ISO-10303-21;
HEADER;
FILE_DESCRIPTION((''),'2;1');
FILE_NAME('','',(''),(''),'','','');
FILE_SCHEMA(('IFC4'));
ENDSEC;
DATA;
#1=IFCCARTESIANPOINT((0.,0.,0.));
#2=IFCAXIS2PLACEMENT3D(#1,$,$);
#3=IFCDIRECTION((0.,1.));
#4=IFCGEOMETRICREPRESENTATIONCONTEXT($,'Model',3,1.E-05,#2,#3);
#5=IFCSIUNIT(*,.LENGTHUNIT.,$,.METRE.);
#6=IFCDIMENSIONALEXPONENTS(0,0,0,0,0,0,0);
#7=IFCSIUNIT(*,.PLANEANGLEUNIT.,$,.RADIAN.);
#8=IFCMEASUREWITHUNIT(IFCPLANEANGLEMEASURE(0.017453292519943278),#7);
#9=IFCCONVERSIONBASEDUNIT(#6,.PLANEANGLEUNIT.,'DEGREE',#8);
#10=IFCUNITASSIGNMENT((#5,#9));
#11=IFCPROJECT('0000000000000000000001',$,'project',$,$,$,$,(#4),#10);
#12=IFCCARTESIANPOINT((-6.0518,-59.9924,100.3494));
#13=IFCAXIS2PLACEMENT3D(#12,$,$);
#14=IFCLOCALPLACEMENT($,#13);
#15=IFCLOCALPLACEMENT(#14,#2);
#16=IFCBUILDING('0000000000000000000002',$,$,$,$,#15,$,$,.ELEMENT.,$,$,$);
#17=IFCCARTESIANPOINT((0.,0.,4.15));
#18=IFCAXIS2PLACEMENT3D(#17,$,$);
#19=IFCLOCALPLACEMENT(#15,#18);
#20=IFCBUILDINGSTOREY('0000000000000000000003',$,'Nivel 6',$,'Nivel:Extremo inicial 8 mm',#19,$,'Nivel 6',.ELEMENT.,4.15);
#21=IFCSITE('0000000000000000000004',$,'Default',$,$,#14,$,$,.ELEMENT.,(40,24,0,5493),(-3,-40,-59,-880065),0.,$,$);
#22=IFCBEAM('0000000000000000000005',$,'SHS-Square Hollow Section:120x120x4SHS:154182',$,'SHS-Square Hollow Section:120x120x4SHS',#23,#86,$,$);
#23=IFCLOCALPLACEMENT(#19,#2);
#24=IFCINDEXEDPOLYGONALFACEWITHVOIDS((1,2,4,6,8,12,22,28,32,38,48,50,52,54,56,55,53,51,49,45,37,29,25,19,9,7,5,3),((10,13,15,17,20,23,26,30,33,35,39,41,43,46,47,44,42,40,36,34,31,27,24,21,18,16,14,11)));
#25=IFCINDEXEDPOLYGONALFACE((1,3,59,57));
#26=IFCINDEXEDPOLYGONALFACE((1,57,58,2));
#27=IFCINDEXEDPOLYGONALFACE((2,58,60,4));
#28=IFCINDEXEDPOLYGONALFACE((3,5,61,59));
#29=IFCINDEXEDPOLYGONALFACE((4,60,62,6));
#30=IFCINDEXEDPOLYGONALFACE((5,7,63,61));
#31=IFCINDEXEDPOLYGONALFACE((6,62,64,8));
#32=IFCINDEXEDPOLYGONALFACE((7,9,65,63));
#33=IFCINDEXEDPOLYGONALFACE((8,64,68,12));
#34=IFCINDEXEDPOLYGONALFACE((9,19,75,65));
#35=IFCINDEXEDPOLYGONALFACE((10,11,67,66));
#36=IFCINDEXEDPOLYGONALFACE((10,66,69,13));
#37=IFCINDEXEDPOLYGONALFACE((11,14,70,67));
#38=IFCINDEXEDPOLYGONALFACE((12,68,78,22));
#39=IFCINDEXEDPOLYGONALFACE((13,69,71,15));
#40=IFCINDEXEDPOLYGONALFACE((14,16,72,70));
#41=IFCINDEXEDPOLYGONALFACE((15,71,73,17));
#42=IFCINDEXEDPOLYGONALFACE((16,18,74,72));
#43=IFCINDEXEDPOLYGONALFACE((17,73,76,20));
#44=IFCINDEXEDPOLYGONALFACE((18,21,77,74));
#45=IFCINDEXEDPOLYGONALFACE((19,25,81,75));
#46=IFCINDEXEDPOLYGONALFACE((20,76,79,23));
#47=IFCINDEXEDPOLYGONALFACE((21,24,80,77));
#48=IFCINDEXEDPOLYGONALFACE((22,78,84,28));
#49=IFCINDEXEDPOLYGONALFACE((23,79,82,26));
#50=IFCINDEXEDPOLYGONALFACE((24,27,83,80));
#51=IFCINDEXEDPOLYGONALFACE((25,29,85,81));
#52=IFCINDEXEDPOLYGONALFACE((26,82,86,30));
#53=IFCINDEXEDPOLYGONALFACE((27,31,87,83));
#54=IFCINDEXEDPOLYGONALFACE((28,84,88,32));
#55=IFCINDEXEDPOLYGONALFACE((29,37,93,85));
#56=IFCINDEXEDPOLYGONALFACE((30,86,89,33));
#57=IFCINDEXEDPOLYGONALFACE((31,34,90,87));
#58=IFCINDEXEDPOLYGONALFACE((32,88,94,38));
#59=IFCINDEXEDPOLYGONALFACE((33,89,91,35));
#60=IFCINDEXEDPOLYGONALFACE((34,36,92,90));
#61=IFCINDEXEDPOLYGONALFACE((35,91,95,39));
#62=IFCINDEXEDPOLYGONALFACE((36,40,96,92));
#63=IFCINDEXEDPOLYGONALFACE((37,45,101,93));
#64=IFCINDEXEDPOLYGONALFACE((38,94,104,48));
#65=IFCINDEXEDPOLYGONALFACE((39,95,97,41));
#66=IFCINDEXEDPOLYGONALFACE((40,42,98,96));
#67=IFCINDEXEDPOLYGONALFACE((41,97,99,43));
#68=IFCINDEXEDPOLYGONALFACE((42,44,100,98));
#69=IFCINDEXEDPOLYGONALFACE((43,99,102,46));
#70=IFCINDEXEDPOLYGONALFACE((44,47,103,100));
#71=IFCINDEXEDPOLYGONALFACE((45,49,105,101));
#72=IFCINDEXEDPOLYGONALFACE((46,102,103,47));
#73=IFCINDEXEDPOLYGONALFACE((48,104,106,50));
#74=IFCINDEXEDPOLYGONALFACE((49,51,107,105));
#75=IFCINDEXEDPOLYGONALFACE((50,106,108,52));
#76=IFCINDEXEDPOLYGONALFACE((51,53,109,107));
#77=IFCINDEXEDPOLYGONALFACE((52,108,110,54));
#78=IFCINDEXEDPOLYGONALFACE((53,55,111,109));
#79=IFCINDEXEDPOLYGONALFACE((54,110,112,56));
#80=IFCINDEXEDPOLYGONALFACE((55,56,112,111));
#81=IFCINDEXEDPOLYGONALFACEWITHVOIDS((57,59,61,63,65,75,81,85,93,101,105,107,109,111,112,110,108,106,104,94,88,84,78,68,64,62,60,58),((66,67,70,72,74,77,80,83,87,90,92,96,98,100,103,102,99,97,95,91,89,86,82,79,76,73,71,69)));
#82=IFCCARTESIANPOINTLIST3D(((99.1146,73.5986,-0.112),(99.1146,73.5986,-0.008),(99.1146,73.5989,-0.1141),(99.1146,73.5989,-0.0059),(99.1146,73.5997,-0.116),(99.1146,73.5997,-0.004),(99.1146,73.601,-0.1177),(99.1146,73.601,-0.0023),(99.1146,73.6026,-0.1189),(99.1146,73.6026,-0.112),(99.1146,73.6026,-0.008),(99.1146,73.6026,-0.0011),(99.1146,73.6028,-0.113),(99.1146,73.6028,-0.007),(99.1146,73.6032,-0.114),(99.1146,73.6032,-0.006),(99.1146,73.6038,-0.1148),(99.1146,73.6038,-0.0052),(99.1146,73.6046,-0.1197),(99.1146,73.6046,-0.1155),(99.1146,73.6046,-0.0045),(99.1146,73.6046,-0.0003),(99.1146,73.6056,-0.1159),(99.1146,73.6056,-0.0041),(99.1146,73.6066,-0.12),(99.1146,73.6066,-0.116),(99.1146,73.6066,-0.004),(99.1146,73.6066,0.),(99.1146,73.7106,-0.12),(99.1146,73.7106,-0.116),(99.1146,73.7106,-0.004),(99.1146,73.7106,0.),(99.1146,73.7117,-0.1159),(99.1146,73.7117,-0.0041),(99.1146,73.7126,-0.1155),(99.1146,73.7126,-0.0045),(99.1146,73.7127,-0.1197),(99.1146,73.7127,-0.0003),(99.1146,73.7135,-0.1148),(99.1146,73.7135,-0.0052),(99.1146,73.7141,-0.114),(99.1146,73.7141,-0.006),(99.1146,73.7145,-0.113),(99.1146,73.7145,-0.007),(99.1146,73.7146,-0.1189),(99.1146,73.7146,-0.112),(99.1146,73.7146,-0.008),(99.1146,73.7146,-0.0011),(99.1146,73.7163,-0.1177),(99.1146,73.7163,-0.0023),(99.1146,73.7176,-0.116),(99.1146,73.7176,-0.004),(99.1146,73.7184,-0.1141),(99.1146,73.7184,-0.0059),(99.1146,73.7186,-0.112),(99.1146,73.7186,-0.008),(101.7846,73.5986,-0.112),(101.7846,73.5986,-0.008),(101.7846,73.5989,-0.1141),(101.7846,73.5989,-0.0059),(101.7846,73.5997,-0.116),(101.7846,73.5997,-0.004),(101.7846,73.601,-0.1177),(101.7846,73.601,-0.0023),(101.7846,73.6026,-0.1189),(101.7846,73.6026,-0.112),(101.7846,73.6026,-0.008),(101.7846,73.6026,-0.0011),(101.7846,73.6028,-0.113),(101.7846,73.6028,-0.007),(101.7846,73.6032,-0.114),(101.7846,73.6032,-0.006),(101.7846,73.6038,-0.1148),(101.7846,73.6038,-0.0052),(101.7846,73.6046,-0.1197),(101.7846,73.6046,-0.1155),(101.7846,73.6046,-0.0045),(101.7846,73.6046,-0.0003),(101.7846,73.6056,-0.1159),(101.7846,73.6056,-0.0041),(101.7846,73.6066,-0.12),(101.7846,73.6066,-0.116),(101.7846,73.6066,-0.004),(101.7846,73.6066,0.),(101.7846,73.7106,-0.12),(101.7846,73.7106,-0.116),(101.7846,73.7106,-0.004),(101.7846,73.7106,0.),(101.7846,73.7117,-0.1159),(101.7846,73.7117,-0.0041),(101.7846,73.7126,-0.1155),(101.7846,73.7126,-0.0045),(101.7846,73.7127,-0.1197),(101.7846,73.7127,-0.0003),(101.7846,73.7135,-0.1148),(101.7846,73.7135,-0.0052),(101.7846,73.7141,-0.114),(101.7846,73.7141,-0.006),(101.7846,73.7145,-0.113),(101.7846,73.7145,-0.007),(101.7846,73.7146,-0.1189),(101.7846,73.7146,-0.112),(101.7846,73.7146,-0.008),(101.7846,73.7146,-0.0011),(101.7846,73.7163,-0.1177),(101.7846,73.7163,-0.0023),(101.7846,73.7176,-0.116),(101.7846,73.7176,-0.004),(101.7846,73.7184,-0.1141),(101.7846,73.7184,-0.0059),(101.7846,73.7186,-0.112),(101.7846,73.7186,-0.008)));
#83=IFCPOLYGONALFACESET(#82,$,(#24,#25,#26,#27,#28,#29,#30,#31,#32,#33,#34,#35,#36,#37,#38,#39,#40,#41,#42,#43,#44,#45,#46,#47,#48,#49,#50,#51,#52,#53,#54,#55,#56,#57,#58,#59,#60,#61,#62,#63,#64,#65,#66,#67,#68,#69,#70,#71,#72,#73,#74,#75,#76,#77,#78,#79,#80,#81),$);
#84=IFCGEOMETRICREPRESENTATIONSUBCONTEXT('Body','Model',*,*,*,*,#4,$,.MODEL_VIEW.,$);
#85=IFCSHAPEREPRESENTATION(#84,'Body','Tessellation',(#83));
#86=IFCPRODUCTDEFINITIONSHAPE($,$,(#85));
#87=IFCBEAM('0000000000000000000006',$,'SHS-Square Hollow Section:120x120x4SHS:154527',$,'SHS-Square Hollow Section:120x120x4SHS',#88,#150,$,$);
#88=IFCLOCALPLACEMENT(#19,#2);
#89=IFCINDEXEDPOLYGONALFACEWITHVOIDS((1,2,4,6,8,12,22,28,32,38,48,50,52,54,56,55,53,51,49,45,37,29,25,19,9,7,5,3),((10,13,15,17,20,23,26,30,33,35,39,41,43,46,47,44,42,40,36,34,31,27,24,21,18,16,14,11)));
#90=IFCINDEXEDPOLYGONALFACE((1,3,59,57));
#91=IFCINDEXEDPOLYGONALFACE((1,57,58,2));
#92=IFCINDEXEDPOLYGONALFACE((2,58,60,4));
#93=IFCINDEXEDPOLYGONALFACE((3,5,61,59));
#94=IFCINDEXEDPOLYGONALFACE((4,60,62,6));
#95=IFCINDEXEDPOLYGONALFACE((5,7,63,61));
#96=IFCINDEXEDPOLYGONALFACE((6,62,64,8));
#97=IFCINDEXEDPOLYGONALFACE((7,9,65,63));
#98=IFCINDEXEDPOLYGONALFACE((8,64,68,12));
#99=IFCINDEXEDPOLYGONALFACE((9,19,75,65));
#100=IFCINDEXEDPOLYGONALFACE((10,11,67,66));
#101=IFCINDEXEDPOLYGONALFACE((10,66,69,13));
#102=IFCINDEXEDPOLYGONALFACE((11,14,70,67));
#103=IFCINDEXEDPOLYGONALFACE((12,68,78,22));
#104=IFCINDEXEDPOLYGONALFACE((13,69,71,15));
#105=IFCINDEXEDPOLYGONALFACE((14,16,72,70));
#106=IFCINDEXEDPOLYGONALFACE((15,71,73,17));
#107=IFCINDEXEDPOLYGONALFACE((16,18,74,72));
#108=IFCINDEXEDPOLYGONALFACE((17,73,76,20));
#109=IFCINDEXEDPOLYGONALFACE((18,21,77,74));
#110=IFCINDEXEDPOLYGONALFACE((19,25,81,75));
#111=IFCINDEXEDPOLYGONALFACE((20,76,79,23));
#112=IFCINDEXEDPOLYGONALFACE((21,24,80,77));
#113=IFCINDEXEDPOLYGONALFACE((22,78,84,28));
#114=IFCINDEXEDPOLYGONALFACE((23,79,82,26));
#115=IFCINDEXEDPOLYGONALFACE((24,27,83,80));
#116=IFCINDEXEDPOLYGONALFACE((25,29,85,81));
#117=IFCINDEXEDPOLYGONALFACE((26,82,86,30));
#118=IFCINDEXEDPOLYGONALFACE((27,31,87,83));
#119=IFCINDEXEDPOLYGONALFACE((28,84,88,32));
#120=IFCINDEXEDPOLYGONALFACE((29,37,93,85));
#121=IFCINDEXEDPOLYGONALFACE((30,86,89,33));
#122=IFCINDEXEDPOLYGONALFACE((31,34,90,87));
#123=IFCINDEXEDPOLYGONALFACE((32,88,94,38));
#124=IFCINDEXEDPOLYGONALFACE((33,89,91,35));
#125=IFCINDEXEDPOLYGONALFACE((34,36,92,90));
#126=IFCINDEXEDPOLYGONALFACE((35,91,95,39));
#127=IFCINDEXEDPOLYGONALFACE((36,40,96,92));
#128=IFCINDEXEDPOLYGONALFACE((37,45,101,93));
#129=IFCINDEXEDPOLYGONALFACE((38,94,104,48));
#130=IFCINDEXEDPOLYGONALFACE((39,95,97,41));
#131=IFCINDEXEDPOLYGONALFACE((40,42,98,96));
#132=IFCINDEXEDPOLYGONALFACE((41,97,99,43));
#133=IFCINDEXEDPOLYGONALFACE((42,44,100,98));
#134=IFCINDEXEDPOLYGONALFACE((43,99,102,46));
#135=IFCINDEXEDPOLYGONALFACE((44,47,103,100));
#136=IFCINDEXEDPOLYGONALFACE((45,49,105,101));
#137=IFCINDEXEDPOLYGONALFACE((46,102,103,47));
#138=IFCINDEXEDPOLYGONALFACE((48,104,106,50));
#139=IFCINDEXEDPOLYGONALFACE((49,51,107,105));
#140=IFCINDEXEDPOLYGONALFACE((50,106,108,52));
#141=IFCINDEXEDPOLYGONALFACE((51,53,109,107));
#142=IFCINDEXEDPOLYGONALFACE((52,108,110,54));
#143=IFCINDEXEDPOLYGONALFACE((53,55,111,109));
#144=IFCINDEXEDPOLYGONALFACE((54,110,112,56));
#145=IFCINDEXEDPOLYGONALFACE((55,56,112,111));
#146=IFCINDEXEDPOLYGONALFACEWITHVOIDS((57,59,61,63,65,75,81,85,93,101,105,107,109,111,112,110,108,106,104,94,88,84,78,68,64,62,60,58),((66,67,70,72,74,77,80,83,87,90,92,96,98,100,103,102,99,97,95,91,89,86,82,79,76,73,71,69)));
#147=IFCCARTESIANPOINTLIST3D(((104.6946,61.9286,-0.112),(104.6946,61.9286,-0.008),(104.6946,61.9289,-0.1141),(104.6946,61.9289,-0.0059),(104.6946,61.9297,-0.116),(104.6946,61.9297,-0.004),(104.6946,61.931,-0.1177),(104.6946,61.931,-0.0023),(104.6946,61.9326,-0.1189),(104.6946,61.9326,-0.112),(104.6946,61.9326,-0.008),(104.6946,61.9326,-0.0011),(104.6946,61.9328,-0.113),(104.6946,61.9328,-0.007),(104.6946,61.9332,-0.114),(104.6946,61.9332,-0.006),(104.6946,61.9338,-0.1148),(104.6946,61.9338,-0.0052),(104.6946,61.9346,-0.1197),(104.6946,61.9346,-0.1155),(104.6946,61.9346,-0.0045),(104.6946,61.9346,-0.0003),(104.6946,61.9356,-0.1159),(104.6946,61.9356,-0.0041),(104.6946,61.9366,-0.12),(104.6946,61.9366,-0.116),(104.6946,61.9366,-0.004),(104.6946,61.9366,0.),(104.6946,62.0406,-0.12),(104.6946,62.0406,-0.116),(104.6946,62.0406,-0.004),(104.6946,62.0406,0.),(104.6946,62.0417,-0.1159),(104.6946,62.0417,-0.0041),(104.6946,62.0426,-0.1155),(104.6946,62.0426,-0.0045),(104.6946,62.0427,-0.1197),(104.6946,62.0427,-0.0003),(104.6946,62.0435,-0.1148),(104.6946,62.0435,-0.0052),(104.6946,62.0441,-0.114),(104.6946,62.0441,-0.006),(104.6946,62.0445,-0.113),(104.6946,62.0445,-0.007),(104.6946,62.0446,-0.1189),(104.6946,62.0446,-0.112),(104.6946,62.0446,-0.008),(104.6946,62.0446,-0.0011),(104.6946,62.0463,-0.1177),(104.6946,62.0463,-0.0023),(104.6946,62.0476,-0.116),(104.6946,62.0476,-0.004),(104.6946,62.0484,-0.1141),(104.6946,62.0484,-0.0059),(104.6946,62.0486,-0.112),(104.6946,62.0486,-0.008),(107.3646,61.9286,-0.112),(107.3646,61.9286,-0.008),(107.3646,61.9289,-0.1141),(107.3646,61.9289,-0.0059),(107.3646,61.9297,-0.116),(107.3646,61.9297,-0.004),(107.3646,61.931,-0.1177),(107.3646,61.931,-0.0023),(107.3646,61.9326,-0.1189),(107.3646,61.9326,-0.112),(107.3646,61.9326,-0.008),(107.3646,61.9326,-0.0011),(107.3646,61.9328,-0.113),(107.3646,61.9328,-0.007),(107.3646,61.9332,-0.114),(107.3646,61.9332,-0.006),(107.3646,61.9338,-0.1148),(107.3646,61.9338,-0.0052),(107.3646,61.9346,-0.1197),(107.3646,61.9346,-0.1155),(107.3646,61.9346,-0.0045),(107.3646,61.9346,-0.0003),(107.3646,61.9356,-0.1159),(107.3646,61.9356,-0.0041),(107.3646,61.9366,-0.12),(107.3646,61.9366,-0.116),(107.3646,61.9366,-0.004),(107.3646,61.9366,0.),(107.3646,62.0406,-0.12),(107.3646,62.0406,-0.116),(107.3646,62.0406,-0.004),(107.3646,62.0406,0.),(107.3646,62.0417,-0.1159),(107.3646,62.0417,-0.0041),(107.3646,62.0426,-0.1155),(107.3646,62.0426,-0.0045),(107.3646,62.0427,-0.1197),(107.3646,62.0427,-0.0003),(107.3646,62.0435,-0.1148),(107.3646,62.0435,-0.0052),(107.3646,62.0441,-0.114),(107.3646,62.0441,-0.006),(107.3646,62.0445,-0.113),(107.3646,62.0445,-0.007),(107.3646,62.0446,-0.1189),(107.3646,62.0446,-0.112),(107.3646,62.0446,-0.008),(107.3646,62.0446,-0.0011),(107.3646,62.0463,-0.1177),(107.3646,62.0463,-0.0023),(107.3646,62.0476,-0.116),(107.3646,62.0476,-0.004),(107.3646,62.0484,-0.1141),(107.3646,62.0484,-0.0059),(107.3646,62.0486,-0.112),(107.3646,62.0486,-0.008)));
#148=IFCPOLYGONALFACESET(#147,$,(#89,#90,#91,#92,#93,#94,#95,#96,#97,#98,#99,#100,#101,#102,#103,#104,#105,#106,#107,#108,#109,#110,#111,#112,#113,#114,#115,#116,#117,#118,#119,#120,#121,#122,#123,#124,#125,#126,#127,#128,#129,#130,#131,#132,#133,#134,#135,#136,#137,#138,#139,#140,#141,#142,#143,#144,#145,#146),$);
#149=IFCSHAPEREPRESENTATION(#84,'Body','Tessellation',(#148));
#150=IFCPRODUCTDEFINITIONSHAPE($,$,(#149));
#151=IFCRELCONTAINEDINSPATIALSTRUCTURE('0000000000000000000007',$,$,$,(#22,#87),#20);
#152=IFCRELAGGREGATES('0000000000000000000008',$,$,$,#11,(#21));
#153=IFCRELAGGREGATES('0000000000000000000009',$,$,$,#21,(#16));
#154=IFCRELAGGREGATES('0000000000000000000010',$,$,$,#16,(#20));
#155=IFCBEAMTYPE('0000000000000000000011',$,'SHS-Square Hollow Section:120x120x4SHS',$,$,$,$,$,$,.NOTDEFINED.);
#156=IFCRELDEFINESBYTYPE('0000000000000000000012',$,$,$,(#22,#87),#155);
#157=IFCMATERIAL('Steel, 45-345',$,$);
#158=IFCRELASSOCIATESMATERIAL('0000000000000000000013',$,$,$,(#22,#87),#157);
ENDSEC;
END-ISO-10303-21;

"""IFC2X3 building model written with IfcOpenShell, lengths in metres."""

from ifc_helpers import new_model, entity, si_unit, converted_unit, direction, frame, frame_2d, origin, place, context, subcontext, project, spatial, polyline, circle_curve, parameter, trimmed, segment, composite_curve, outline, extrude, material, type_object, element, save


model = new_model("IFC2X3")

# Units and contexts
model_context = context("Model", 3, precision=1e-05, world=origin(), true_north=direction((0.0, 1.0)))
body_context = subcontext(model_context, "Body", "Model", "MODEL_VIEW")
ifc_project = project(units=[si_unit("LENGTHUNIT", "METRE"), converted_unit("PLANEANGLEUNIT", "DEGREE", entity("IfcPlaneAngleMeasure", 0.017453292519943278), si_unit("PLANEANGLEUNIT", "RADIAN"), dimensions=[0, 0, 0, 0, 0, 0, 0])], contexts=[model_context])

# Site, building, storey
site_placement = place(None, frame((-6.0518, -59.9924, 100.3494)))
site = spatial("IfcSite", under=ifc_project, at=site_placement, Name="Default", CompositionType="ELEMENT", RefLatitude=(40, 24, 0, 5493), RefLongitude=(-3, -40, -59, -880065), RefElevation=0.0)
building_placement = place(site_placement, origin())
building = spatial("IfcBuilding", under=site, at=building_placement, CompositionType="ELEMENT")
storey_placement = place(building_placement, frame((0.0, 0.0, 4.15)))
storey = spatial("IfcBuildingStorey", under=building, at=storey_placement, Name="Nivel 6", ObjectType="Nivel:Extremo inicial 8 mm", LongName="Nivel 6", CompositionType="ELEMENT", Elevation=4.15)

# Beams
ifc_material_1 = material(Name="Steel, 45-345")
beam_type_1 = type_object("IfcBeamType", Name="SHS-Square Hollow Section:120x120x4SHS", PredefinedType="NOTDEFINED")
beam_1_placement = place(storey_placement, frame((101.8446, 73.6586, 0.0), z_axis=(0.0, 0.0, 1.0), x_axis=(-1.0, 0.0, 0.0)))
element("IfcBeam", 1, at=beam_1_placement, inside=storey, type_object=beam_type_1, material=ifc_material_1, Name="SHS-Square Hollow Section:120x120x4SHS:154182", ObjectType="SHS-Square Hollow Section:120x120x4SHS", context=body_context, shape_type="SweptSolid", body=[
    extrude(outline(composite_curve([segment(trimmed(circle_curve(frame_2d((-0.052, -0.052), x_axis=(1.0, 0.0)), 0.008), [parameter(180.0)], [parameter(270.0)], True, "PARAMETER"), True, "CONTINUOUS"), segment(polyline([(-0.052, -0.06), (0.052, -0.06)]), True, "CONTINUOUS"), segment(trimmed(circle_curve(frame_2d((0.052, -0.052), x_axis=(1.0, 0.0)), 0.008), [parameter(270.0)], [parameter(0.0)], True, "PARAMETER"), True, "CONTINUOUS"), segment(polyline([(0.06, -0.052), (0.06, 0.052)]), True, "CONTINUOUS"), segment(trimmed(circle_curve(frame_2d((0.052, 0.052), x_axis=(1.0, 0.0)), 0.008), [parameter(360.0)], [parameter(90.0)], True, "PARAMETER"), True, "CONTINUOUS"), segment(polyline([(0.052, 0.06), (-0.052, 0.06)]), True, "CONTINUOUS"), segment(trimmed(circle_curve(frame_2d((-0.052, 0.052), x_axis=(1.0, 0.0)), 0.008), [parameter(90.0)], [parameter(180.0)], True, "PARAMETER"), True, "CONTINUOUS"), segment(polyline([(-0.06, 0.052), (-0.06, -0.052)]), True, "CONTINUOUS")], self_intersect=False), holes=[composite_curve([segment(polyline([(0.052, -0.056), (-0.052, -0.056)]), True, "CONTINUOUS"), segment(trimmed(circle_curve(frame_2d((-0.052, -0.052), x_axis=(1.0, 0.0)), 0.004), [parameter(180.0)], [parameter(270.0)], True, "PARAMETER"), False, "CONTINUOUS"), segment(polyline([(-0.056, -0.052), (-0.056, 0.052)]), True, "CONTINUOUS"), segment(trimmed(circle_curve(frame_2d((-0.052, 0.052), x_axis=(1.0, 0.0)), 0.004), [parameter(90.0)], [parameter(180.0)], True, "PARAMETER"), False, "CONTINUOUS"), segment(polyline([(-0.052, 0.056), (0.052, 0.056)]), True, "CONTINUOUS"), segment(trimmed(circle_curve(frame_2d((0.052, 0.052), x_axis=(1.0, 0.0)), 0.004), [parameter(0.0)], [parameter(90.0)], True, "PARAMETER"), False, "CONTINUOUS"), segment(polyline([(0.056, 0.052), (0.056, -0.052)]), True, "CONTINUOUS"), segment(trimmed(circle_curve(frame_2d((0.052, -0.052), x_axis=(1.0, 0.0)), 0.004), [parameter(270.0)], [parameter(0.0)], True, "PARAMETER"), False, "CONTINUOUS")], self_intersect=False)]), frame((0.06, 0.0, -0.06), z_axis=(1.0, 0.0, 0.0), x_axis=(0.0, -1.0, 0.0)), (0.0, 0.0, 1.0), 2.67),
])
beam_2_placement = place(storey_placement, frame((107.4246, 61.9886, 0.0), z_axis=(0.0, 0.0, 1.0), x_axis=(-1.0, 0.0, 0.0)))
element("IfcBeam", 2, at=beam_2_placement, inside=storey, type_object=beam_type_1, material=ifc_material_1, Name="SHS-Square Hollow Section:120x120x4SHS:154527", ObjectType="SHS-Square Hollow Section:120x120x4SHS", context=body_context, shape_type="SweptSolid", body=[
    extrude(outline(composite_curve([segment(trimmed(circle_curve(frame_2d((-0.052, -0.052), x_axis=(1.0, 0.0)), 0.008), [parameter(180.0)], [parameter(270.0)], True, "PARAMETER"), True, "CONTINUOUS"), segment(polyline([(-0.052, -0.06), (0.052, -0.06)]), True, "CONTINUOUS"), segment(trimmed(circle_curve(frame_2d((0.052, -0.052), x_axis=(1.0, 0.0)), 0.008), [parameter(270.0)], [parameter(0.0)], True, "PARAMETER"), True, "CONTINUOUS"), segment(polyline([(0.06, -0.052), (0.06, 0.052)]), True, "CONTINUOUS"), segment(trimmed(circle_curve(frame_2d((0.052, 0.052), x_axis=(1.0, 0.0)), 0.008), [parameter(360.0)], [parameter(90.0)], True, "PARAMETER"), True, "CONTINUOUS"), segment(polyline([(0.052, 0.06), (-0.052, 0.06)]), True, "CONTINUOUS"), segment(trimmed(circle_curve(frame_2d((-0.052, 0.052), x_axis=(1.0, 0.0)), 0.008), [parameter(90.0)], [parameter(180.0)], True, "PARAMETER"), True, "CONTINUOUS"), segment(polyline([(-0.06, 0.052), (-0.06, -0.052)]), True, "CONTINUOUS")], self_intersect=False), holes=[composite_curve([segment(polyline([(0.052, -0.056), (-0.052, -0.056)]), True, "CONTINUOUS"), segment(trimmed(circle_curve(frame_2d((-0.052, -0.052), x_axis=(1.0, 0.0)), 0.004), [parameter(180.0)], [parameter(270.0)], True, "PARAMETER"), False, "CONTINUOUS"), segment(polyline([(-0.056, -0.052), (-0.056, 0.052)]), True, "CONTINUOUS"), segment(trimmed(circle_curve(frame_2d((-0.052, 0.052), x_axis=(1.0, 0.0)), 0.004), [parameter(90.0)], [parameter(180.0)], True, "PARAMETER"), False, "CONTINUOUS"), segment(polyline([(-0.052, 0.056), (0.052, 0.056)]), True, "CONTINUOUS"), segment(trimmed(circle_curve(frame_2d((0.052, 0.052), x_axis=(1.0, 0.0)), 0.004), [parameter(0.0)], [parameter(90.0)], True, "PARAMETER"), False, "CONTINUOUS"), segment(polyline([(0.056, 0.052), (0.056, -0.052)]), True, "CONTINUOUS"), segment(trimmed(circle_curve(frame_2d((0.052, -0.052), x_axis=(1.0, 0.0)), 0.004), [parameter(270.0)], [parameter(0.0)], True, "PARAMETER"), False, "CONTINUOUS")], self_intersect=False)]), frame((0.06, 0.0, -0.06), z_axis=(1.0, 0.0, 0.0), x_axis=(0.0, -1.0, 0.0)), (0.0, 0.0, 1.0), 2.67),
])

save(model, "model.ifc")
